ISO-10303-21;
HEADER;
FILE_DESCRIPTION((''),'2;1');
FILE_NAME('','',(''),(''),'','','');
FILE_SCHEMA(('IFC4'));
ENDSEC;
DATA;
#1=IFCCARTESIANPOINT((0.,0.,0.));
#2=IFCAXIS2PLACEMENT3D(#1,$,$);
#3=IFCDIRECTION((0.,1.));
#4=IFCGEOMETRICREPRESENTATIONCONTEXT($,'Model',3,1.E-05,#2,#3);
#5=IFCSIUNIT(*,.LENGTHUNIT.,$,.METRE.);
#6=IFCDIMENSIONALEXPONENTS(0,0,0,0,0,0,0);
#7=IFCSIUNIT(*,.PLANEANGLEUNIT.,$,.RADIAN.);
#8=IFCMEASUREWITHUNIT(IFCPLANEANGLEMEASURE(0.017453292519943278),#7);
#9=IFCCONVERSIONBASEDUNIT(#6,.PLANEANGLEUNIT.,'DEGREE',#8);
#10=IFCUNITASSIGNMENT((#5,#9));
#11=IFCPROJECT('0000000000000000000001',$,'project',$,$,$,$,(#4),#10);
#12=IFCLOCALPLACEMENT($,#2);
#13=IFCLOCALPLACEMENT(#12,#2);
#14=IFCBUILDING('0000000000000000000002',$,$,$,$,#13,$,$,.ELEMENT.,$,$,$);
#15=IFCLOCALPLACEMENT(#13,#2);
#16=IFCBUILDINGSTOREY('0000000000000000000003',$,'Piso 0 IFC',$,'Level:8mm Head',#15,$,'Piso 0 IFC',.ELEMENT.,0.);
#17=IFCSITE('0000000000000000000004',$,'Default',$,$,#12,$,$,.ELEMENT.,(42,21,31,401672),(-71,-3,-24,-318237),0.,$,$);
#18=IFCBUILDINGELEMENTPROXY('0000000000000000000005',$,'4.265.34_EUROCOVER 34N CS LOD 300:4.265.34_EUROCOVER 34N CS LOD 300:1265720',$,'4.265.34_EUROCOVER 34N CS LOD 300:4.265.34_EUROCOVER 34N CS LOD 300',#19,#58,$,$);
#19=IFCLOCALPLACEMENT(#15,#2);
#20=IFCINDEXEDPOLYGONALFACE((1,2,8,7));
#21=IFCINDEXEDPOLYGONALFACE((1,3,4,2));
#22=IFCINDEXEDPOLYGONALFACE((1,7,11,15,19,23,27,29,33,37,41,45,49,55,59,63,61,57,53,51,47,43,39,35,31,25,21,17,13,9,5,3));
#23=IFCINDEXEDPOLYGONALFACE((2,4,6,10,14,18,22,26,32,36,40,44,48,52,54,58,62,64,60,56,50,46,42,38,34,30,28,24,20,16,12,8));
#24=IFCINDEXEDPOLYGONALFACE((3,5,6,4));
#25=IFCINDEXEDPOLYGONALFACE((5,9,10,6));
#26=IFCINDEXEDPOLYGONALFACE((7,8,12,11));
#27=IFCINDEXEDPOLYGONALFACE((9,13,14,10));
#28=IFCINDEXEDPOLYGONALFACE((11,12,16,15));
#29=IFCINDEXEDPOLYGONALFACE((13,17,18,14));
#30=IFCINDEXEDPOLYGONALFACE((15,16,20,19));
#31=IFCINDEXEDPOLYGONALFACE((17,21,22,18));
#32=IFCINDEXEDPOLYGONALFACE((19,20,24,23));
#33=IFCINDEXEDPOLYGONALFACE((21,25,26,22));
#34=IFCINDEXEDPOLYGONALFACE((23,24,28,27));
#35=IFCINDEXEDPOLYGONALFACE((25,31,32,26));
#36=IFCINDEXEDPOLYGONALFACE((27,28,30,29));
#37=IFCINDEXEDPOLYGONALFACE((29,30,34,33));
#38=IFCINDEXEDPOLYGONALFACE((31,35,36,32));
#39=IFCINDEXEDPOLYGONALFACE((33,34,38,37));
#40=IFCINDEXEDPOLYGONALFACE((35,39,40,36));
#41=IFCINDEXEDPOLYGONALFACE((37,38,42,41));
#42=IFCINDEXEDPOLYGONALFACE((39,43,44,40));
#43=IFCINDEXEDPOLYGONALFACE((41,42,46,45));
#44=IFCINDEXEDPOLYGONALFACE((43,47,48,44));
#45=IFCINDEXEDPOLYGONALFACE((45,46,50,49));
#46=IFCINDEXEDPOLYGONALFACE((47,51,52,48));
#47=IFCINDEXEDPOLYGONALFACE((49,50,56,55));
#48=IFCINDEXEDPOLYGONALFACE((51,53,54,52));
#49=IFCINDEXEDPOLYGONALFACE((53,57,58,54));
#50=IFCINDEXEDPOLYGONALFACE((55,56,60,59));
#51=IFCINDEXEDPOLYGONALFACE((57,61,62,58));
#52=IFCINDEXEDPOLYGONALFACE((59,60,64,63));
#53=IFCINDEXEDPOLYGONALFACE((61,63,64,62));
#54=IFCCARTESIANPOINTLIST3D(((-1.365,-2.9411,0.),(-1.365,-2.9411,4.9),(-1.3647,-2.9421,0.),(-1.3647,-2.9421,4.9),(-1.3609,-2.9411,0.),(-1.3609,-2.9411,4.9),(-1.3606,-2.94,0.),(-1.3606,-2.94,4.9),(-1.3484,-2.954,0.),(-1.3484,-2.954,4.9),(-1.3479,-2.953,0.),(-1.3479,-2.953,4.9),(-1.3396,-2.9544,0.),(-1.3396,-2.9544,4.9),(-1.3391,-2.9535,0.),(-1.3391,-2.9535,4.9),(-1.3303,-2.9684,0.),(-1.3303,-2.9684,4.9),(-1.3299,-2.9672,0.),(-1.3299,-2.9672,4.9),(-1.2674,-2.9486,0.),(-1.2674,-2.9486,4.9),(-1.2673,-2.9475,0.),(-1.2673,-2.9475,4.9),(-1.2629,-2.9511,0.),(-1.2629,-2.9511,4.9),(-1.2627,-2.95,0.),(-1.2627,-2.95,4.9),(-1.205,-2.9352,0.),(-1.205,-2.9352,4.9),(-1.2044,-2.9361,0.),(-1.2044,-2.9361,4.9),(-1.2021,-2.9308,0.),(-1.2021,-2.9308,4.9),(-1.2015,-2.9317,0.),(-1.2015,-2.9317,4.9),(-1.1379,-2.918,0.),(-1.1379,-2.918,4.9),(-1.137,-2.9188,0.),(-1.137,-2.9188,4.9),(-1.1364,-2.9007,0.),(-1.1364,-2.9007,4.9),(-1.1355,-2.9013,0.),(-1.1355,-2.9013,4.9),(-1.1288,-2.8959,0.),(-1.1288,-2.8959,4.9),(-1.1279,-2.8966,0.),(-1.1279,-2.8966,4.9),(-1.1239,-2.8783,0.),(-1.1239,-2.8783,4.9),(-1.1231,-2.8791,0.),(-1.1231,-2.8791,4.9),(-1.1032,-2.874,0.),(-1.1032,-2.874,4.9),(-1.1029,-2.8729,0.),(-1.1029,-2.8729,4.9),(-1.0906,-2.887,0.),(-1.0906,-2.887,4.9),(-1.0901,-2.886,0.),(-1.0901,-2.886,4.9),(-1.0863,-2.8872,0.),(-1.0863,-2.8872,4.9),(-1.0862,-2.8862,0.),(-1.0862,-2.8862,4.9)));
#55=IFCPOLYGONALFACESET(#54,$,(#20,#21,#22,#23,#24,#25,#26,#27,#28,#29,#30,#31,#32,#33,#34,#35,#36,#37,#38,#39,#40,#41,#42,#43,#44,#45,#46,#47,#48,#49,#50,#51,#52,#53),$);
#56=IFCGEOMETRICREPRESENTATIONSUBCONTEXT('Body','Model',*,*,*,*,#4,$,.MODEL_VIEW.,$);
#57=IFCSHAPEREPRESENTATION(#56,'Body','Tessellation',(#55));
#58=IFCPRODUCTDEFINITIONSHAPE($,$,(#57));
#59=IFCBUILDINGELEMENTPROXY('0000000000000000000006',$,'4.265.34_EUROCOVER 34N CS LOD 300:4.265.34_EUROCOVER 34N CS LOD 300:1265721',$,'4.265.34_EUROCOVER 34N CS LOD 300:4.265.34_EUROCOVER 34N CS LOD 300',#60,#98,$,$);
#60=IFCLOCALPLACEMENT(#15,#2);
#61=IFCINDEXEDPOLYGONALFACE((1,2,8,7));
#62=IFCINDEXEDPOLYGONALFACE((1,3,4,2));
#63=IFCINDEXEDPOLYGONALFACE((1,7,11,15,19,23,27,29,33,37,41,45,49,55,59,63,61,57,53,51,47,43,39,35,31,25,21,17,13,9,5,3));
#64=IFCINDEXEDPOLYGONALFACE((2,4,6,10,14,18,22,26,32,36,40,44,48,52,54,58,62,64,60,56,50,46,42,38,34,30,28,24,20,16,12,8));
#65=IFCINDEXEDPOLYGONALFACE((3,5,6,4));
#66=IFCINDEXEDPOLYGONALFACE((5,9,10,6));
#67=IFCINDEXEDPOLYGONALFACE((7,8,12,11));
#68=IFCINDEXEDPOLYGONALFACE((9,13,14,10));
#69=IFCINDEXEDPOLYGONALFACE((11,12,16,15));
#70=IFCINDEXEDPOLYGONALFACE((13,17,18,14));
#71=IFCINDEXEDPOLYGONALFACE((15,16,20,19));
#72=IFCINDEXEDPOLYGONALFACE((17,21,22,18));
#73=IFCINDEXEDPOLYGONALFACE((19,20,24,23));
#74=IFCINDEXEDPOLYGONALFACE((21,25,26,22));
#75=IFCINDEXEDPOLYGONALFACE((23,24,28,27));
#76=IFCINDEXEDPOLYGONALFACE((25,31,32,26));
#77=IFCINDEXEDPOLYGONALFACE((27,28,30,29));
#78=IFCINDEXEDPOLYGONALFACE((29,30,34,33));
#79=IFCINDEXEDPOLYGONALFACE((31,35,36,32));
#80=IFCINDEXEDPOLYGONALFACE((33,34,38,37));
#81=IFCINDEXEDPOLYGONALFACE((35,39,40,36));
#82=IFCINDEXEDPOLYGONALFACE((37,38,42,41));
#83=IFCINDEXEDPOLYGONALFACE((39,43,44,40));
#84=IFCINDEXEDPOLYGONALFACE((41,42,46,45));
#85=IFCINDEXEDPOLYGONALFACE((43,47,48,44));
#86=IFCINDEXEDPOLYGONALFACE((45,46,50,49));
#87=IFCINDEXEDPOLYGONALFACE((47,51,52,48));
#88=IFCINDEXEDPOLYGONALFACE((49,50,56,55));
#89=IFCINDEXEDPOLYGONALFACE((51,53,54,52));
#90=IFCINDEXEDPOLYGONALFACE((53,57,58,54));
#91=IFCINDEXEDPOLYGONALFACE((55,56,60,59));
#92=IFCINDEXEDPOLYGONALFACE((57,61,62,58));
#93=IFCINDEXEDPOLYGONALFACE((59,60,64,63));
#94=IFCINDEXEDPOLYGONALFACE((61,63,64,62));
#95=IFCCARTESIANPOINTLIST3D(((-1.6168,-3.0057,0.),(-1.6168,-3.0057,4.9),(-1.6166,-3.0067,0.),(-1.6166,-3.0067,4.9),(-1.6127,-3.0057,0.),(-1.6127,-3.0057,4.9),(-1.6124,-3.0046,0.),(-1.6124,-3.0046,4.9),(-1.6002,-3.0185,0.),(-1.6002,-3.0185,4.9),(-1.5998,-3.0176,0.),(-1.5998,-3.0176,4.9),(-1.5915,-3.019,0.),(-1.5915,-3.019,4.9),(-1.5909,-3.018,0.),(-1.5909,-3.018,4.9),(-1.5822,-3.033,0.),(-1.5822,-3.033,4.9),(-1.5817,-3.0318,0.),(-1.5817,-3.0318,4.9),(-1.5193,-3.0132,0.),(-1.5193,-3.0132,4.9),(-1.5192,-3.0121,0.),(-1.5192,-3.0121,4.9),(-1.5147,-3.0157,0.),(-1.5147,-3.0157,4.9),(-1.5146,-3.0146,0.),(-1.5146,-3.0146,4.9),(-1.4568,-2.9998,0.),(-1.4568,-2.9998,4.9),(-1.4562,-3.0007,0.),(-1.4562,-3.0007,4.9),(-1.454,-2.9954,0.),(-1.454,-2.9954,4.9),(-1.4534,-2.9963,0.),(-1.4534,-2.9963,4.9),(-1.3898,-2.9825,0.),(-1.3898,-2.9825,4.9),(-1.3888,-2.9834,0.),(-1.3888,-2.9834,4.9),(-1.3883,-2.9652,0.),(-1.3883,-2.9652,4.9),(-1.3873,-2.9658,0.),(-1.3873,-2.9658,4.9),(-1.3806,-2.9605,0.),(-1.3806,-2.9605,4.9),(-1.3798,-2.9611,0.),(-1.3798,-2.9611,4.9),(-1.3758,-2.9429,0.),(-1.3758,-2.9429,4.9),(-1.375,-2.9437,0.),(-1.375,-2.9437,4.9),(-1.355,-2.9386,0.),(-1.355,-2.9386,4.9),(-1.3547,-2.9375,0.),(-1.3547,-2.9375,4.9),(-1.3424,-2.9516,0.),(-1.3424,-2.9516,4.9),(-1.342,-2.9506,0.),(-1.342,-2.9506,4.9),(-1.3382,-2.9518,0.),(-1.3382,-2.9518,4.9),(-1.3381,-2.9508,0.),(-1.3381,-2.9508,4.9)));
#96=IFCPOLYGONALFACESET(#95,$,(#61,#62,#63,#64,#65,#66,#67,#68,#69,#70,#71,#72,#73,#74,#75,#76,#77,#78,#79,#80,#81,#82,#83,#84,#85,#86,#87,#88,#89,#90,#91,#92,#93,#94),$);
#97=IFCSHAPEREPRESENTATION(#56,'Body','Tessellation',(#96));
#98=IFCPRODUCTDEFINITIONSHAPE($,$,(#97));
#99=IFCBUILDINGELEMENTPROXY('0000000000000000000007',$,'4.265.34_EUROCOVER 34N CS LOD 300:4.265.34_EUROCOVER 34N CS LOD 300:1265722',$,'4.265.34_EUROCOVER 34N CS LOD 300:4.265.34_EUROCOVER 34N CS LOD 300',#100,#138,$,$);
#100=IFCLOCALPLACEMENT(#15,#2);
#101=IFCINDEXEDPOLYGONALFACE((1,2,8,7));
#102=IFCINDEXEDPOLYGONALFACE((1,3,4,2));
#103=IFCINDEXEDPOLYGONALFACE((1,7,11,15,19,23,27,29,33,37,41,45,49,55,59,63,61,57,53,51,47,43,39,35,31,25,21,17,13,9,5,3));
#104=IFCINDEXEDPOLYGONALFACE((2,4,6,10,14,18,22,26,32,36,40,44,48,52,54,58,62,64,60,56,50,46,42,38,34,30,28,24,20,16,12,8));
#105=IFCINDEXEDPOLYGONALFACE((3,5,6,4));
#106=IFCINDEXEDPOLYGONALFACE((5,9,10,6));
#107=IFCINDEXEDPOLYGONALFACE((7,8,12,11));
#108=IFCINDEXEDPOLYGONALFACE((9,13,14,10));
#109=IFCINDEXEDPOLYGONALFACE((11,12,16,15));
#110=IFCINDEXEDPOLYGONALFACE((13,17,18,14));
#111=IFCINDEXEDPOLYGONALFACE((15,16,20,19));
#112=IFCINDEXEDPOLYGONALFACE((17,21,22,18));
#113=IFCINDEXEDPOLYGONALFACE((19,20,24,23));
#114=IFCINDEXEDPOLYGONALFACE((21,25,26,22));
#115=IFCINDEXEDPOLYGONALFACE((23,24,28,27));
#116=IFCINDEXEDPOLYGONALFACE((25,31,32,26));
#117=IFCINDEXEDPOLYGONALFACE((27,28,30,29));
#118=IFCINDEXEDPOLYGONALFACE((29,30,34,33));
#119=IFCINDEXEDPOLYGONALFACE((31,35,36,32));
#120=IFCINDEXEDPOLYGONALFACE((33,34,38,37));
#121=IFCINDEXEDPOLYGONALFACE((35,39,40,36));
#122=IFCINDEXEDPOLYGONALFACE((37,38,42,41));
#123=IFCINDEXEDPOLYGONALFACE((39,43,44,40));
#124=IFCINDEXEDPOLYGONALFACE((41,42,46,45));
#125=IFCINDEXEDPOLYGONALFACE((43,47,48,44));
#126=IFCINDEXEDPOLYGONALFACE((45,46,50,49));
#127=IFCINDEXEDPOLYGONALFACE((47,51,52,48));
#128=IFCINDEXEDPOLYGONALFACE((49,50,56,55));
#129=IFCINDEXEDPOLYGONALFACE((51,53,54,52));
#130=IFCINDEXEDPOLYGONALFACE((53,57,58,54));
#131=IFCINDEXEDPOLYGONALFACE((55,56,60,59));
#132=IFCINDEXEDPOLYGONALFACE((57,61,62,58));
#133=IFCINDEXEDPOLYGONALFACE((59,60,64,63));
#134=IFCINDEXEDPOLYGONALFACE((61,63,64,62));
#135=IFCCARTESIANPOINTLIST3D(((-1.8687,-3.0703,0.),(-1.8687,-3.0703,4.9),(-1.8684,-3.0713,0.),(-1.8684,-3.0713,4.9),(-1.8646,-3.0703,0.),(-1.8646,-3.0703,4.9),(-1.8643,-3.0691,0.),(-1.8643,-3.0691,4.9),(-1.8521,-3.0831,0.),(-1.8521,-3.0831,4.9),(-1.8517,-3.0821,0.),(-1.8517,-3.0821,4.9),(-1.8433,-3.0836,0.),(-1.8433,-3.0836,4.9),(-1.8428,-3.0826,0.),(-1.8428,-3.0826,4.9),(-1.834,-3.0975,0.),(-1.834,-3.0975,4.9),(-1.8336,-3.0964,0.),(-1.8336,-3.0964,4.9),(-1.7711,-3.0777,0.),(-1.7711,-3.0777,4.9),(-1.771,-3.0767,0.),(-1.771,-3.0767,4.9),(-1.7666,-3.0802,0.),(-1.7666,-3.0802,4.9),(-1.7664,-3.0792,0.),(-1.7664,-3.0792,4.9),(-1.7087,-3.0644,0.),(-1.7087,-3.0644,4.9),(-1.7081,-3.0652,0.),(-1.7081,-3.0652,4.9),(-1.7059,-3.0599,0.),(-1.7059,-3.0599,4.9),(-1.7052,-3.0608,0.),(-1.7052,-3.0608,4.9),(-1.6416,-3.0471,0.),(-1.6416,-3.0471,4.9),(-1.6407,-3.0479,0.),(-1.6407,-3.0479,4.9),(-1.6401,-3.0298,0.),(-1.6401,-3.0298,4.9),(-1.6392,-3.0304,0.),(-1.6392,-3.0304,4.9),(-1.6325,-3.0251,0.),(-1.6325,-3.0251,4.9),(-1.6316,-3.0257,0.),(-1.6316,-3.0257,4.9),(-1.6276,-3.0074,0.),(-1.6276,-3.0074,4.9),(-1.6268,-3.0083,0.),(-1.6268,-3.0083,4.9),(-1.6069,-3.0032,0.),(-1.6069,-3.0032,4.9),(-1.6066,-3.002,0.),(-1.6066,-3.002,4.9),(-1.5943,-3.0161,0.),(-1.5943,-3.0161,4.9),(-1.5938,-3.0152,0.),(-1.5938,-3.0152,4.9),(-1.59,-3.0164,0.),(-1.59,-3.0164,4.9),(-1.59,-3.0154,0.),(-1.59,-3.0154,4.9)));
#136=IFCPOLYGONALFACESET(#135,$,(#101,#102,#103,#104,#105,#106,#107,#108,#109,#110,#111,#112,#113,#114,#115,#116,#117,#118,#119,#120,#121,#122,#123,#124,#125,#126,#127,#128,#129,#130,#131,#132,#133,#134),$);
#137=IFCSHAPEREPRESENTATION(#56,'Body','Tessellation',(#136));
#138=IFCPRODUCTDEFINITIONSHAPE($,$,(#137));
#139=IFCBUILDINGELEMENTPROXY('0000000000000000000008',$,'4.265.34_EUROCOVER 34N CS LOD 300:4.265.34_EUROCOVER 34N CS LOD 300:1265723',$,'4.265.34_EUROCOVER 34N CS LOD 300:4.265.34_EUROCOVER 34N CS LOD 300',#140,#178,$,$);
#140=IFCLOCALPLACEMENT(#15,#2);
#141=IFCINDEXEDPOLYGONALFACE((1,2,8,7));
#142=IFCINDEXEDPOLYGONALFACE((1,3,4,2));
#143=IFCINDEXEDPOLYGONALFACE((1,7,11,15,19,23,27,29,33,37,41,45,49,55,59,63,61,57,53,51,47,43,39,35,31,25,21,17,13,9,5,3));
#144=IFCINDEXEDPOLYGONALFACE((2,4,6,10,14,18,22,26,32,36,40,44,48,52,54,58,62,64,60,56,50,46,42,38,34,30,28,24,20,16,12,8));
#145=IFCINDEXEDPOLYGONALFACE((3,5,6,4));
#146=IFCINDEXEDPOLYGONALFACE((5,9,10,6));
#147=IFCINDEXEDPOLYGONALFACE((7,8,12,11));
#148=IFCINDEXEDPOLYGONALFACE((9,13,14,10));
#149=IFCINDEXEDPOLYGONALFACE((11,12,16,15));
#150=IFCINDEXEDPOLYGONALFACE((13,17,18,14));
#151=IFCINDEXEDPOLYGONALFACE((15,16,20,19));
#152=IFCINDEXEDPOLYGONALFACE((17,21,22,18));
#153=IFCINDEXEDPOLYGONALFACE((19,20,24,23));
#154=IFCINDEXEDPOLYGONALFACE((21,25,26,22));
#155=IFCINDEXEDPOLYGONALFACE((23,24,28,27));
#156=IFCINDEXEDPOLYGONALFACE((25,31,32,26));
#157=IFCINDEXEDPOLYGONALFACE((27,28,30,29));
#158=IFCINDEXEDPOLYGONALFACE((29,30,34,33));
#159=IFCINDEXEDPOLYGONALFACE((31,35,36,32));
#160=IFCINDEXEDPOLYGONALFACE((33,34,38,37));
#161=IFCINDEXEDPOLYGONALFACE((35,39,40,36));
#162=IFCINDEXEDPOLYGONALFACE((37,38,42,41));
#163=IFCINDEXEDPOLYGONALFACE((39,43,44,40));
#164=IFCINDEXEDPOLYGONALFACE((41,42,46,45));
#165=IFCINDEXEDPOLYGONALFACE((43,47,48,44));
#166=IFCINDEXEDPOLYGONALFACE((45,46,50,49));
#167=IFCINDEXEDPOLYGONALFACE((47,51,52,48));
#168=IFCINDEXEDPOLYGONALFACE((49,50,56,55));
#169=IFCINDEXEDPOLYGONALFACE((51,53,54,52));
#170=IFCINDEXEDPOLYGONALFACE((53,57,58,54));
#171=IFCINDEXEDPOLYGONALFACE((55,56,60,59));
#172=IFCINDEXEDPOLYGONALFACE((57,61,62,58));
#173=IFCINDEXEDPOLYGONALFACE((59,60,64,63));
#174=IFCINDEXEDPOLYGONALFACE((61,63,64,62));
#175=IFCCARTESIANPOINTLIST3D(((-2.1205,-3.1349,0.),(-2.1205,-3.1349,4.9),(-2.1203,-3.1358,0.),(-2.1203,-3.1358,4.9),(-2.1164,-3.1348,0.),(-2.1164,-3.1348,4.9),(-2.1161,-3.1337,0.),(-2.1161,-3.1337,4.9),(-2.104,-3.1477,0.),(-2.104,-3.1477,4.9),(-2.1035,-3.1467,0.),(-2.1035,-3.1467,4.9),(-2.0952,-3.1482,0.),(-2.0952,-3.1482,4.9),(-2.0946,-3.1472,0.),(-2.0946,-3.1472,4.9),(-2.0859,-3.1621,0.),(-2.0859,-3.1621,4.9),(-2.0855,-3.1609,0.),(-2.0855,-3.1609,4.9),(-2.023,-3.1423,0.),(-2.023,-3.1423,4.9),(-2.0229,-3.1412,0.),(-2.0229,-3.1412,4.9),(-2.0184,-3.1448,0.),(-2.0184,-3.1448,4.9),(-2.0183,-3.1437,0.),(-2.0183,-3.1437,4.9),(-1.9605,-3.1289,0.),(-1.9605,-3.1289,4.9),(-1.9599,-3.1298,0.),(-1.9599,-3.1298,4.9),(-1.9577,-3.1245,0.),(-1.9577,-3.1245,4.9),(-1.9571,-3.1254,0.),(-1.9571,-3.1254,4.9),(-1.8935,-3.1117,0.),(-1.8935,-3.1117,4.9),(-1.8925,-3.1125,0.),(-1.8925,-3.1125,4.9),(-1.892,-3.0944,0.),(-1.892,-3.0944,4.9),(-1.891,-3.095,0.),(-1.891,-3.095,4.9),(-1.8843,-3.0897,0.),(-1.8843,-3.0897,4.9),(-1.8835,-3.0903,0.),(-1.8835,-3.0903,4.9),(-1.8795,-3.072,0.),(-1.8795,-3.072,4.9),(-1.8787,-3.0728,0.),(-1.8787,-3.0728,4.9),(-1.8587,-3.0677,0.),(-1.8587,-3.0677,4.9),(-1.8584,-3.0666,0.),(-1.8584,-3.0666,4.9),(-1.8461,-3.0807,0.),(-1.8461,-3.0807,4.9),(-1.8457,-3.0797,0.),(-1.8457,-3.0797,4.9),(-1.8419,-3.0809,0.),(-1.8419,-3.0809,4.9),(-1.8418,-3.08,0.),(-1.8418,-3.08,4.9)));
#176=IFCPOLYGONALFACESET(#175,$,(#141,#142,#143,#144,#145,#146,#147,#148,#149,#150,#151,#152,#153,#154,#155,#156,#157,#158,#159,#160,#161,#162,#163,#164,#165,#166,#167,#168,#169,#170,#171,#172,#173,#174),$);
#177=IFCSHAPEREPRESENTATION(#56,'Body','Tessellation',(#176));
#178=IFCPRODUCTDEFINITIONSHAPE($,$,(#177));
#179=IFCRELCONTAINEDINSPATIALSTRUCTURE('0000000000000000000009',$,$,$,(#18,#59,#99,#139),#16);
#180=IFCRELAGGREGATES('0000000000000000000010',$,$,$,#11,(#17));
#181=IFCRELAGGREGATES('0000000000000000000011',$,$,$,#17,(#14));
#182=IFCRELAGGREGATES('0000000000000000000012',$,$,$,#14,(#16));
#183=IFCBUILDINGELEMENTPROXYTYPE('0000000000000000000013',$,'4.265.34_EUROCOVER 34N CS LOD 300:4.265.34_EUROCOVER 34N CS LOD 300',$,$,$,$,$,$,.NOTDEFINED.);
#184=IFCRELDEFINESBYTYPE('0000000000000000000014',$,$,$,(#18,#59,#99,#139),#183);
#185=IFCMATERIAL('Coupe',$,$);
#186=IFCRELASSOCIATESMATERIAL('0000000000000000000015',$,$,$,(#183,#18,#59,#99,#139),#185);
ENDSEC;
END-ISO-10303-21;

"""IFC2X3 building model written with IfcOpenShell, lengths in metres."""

from ifc_helpers import new_model, entity, si_unit, converted_unit, direction, frame, origin, place, context, subcontext, project, spatial, polyline, outline, extrude, source, transform, mapped, material, type_object, type_shapes, element, save


model = new_model("IFC2X3")

# Units and contexts
model_context = context("Model", 3, precision=1e-05, world=origin(), true_north=direction((0.0, 1.0)))
body_context = subcontext(model_context, "Body", "Model", "MODEL_VIEW")
ifc_project = project(units=[si_unit("LENGTHUNIT", "METRE"), converted_unit("PLANEANGLEUNIT", "DEGREE", entity("IfcPlaneAngleMeasure", 0.017453292519943278), si_unit("PLANEANGLEUNIT", "RADIAN"), dimensions=[0, 0, 0, 0, 0, 0, 0])], contexts=[model_context])

# Site, building, storey
site_placement = place(None, origin())
site = spatial("IfcSite", under=ifc_project, at=site_placement, Name="Default", CompositionType="ELEMENT", RefLatitude=(42, 21, 31, 401672), RefLongitude=(-71, -3, -24, -318237), RefElevation=0.0)
building_placement = place(site_placement, origin())
building = spatial("IfcBuilding", under=site, at=building_placement, CompositionType="ELEMENT")
storey_placement = place(building_placement, origin())
storey = spatial("IfcBuildingStorey", under=building, at=storey_placement, Name="Piso 0 IFC", ObjectType="Level:8mm Head", LongName="Piso 0 IFC", CompositionType="ELEMENT", Elevation=0.0)

# Building element proxies
ifc_material_1 = material(Name="Coupe")
building_element_proxy_type = type_object("IfcBuildingElementProxyType", Name="4.265.34_EUROCOVER 34N CS LOD 300:4.265.34_EUROCOVER 34N CS LOD 300", PredefinedType="NOTDEFINED", material=ifc_material_1)
shared_shape_1 = source(origin(), body_context, "Body", "SweptSolid", [
    extrude(outline(polyline([(0.0449, 0.1162), (0.063, 0.1162), (0.0661, 0.1191), (0.0654, 0.1198), (0.0626, 0.1172), (0.0443, 0.1172), (0.0335, 0.0983), (0.0428, 0.0826), (0.0409, 0.0738), (0.0522, 0.0606), (0.0167, 0.0056), (0.0179, 0.0005), (-0.0117, -0.0512), (-0.0167, -0.0528), (-0.0462, -0.1114), (-0.0624, -0.1084), (-0.069, -0.1145), (-0.0871, -0.1145), (-0.0893, -0.1184), (-0.0885, -0.1189), (-0.0865, -0.1155), (-0.0686, -0.1155), (-0.0621, -0.1095), (-0.0456, -0.1125), (-0.016, -0.0536), (-0.0111, -0.0521), (0.0189, 0.0004), (0.0177, 0.0054), (0.0535, 0.0607), (0.0419, 0.074), (0.0438, 0.0827), (0.0347, 0.0983), (0.0449, 0.1162)])), frame((-0.0171, -0.0163, 0.0), z_axis=(0.0, 0.0, 1.0), x_axis=(-0.496574, 0.867994, 0.0)), (0.0, 0.0, 1.0), 4.9),
])
type_shapes(building_element_proxy_type, [shared_shape_1])
for number, where, z_axis, x_axis, name in (
    (1, (-1.2304, -2.9428, 0.0), (0.0, 0.0, 1.0), (-0.968666, -0.248367, 0.0), "4.265.34_EUROCOVER 34N CS LOD 300:4.265.34_EUROCOVER 34N CS LOD 300:1265720"),
    (2, (-1.4822, -3.0073, 0.0), (0.0, 0.0, 1.0), (-0.968666, -0.248367, 0.0), "4.265.34_EUROCOVER 34N CS LOD 300:4.265.34_EUROCOVER 34N CS LOD 300:1265721"),
    (3, (-1.7341, -3.0719, 0.0), (0.0, 0.0, 1.0), (-0.968666, -0.248367, 0.0), "4.265.34_EUROCOVER 34N CS LOD 300:4.265.34_EUROCOVER 34N CS LOD 300:1265722"),
    (4, (-1.9859, -3.1365, 0.0), (0.0, 0.0, 1.0), (-0.968666, -0.248367, 0.0), "4.265.34_EUROCOVER 34N CS LOD 300:4.265.34_EUROCOVER 34N CS LOD 300:1265723"),
):
    element("IfcBuildingElementProxy", number, at=place(storey_placement, frame(where, z_axis=z_axis, x_axis=x_axis)), inside=storey, type_object=building_element_proxy_type, material=ifc_material_1, Name=name, ObjectType="4.265.34_EUROCOVER 34N CS LOD 300:4.265.34_EUROCOVER 34N CS LOD 300", context=body_context, shape_type="MappedRepresentation", body=[
        mapped(shared_shape_1, transform((0.0, 0.0, 0.0), scale=1.0)),
    ])

save(model, "model.ifc")
